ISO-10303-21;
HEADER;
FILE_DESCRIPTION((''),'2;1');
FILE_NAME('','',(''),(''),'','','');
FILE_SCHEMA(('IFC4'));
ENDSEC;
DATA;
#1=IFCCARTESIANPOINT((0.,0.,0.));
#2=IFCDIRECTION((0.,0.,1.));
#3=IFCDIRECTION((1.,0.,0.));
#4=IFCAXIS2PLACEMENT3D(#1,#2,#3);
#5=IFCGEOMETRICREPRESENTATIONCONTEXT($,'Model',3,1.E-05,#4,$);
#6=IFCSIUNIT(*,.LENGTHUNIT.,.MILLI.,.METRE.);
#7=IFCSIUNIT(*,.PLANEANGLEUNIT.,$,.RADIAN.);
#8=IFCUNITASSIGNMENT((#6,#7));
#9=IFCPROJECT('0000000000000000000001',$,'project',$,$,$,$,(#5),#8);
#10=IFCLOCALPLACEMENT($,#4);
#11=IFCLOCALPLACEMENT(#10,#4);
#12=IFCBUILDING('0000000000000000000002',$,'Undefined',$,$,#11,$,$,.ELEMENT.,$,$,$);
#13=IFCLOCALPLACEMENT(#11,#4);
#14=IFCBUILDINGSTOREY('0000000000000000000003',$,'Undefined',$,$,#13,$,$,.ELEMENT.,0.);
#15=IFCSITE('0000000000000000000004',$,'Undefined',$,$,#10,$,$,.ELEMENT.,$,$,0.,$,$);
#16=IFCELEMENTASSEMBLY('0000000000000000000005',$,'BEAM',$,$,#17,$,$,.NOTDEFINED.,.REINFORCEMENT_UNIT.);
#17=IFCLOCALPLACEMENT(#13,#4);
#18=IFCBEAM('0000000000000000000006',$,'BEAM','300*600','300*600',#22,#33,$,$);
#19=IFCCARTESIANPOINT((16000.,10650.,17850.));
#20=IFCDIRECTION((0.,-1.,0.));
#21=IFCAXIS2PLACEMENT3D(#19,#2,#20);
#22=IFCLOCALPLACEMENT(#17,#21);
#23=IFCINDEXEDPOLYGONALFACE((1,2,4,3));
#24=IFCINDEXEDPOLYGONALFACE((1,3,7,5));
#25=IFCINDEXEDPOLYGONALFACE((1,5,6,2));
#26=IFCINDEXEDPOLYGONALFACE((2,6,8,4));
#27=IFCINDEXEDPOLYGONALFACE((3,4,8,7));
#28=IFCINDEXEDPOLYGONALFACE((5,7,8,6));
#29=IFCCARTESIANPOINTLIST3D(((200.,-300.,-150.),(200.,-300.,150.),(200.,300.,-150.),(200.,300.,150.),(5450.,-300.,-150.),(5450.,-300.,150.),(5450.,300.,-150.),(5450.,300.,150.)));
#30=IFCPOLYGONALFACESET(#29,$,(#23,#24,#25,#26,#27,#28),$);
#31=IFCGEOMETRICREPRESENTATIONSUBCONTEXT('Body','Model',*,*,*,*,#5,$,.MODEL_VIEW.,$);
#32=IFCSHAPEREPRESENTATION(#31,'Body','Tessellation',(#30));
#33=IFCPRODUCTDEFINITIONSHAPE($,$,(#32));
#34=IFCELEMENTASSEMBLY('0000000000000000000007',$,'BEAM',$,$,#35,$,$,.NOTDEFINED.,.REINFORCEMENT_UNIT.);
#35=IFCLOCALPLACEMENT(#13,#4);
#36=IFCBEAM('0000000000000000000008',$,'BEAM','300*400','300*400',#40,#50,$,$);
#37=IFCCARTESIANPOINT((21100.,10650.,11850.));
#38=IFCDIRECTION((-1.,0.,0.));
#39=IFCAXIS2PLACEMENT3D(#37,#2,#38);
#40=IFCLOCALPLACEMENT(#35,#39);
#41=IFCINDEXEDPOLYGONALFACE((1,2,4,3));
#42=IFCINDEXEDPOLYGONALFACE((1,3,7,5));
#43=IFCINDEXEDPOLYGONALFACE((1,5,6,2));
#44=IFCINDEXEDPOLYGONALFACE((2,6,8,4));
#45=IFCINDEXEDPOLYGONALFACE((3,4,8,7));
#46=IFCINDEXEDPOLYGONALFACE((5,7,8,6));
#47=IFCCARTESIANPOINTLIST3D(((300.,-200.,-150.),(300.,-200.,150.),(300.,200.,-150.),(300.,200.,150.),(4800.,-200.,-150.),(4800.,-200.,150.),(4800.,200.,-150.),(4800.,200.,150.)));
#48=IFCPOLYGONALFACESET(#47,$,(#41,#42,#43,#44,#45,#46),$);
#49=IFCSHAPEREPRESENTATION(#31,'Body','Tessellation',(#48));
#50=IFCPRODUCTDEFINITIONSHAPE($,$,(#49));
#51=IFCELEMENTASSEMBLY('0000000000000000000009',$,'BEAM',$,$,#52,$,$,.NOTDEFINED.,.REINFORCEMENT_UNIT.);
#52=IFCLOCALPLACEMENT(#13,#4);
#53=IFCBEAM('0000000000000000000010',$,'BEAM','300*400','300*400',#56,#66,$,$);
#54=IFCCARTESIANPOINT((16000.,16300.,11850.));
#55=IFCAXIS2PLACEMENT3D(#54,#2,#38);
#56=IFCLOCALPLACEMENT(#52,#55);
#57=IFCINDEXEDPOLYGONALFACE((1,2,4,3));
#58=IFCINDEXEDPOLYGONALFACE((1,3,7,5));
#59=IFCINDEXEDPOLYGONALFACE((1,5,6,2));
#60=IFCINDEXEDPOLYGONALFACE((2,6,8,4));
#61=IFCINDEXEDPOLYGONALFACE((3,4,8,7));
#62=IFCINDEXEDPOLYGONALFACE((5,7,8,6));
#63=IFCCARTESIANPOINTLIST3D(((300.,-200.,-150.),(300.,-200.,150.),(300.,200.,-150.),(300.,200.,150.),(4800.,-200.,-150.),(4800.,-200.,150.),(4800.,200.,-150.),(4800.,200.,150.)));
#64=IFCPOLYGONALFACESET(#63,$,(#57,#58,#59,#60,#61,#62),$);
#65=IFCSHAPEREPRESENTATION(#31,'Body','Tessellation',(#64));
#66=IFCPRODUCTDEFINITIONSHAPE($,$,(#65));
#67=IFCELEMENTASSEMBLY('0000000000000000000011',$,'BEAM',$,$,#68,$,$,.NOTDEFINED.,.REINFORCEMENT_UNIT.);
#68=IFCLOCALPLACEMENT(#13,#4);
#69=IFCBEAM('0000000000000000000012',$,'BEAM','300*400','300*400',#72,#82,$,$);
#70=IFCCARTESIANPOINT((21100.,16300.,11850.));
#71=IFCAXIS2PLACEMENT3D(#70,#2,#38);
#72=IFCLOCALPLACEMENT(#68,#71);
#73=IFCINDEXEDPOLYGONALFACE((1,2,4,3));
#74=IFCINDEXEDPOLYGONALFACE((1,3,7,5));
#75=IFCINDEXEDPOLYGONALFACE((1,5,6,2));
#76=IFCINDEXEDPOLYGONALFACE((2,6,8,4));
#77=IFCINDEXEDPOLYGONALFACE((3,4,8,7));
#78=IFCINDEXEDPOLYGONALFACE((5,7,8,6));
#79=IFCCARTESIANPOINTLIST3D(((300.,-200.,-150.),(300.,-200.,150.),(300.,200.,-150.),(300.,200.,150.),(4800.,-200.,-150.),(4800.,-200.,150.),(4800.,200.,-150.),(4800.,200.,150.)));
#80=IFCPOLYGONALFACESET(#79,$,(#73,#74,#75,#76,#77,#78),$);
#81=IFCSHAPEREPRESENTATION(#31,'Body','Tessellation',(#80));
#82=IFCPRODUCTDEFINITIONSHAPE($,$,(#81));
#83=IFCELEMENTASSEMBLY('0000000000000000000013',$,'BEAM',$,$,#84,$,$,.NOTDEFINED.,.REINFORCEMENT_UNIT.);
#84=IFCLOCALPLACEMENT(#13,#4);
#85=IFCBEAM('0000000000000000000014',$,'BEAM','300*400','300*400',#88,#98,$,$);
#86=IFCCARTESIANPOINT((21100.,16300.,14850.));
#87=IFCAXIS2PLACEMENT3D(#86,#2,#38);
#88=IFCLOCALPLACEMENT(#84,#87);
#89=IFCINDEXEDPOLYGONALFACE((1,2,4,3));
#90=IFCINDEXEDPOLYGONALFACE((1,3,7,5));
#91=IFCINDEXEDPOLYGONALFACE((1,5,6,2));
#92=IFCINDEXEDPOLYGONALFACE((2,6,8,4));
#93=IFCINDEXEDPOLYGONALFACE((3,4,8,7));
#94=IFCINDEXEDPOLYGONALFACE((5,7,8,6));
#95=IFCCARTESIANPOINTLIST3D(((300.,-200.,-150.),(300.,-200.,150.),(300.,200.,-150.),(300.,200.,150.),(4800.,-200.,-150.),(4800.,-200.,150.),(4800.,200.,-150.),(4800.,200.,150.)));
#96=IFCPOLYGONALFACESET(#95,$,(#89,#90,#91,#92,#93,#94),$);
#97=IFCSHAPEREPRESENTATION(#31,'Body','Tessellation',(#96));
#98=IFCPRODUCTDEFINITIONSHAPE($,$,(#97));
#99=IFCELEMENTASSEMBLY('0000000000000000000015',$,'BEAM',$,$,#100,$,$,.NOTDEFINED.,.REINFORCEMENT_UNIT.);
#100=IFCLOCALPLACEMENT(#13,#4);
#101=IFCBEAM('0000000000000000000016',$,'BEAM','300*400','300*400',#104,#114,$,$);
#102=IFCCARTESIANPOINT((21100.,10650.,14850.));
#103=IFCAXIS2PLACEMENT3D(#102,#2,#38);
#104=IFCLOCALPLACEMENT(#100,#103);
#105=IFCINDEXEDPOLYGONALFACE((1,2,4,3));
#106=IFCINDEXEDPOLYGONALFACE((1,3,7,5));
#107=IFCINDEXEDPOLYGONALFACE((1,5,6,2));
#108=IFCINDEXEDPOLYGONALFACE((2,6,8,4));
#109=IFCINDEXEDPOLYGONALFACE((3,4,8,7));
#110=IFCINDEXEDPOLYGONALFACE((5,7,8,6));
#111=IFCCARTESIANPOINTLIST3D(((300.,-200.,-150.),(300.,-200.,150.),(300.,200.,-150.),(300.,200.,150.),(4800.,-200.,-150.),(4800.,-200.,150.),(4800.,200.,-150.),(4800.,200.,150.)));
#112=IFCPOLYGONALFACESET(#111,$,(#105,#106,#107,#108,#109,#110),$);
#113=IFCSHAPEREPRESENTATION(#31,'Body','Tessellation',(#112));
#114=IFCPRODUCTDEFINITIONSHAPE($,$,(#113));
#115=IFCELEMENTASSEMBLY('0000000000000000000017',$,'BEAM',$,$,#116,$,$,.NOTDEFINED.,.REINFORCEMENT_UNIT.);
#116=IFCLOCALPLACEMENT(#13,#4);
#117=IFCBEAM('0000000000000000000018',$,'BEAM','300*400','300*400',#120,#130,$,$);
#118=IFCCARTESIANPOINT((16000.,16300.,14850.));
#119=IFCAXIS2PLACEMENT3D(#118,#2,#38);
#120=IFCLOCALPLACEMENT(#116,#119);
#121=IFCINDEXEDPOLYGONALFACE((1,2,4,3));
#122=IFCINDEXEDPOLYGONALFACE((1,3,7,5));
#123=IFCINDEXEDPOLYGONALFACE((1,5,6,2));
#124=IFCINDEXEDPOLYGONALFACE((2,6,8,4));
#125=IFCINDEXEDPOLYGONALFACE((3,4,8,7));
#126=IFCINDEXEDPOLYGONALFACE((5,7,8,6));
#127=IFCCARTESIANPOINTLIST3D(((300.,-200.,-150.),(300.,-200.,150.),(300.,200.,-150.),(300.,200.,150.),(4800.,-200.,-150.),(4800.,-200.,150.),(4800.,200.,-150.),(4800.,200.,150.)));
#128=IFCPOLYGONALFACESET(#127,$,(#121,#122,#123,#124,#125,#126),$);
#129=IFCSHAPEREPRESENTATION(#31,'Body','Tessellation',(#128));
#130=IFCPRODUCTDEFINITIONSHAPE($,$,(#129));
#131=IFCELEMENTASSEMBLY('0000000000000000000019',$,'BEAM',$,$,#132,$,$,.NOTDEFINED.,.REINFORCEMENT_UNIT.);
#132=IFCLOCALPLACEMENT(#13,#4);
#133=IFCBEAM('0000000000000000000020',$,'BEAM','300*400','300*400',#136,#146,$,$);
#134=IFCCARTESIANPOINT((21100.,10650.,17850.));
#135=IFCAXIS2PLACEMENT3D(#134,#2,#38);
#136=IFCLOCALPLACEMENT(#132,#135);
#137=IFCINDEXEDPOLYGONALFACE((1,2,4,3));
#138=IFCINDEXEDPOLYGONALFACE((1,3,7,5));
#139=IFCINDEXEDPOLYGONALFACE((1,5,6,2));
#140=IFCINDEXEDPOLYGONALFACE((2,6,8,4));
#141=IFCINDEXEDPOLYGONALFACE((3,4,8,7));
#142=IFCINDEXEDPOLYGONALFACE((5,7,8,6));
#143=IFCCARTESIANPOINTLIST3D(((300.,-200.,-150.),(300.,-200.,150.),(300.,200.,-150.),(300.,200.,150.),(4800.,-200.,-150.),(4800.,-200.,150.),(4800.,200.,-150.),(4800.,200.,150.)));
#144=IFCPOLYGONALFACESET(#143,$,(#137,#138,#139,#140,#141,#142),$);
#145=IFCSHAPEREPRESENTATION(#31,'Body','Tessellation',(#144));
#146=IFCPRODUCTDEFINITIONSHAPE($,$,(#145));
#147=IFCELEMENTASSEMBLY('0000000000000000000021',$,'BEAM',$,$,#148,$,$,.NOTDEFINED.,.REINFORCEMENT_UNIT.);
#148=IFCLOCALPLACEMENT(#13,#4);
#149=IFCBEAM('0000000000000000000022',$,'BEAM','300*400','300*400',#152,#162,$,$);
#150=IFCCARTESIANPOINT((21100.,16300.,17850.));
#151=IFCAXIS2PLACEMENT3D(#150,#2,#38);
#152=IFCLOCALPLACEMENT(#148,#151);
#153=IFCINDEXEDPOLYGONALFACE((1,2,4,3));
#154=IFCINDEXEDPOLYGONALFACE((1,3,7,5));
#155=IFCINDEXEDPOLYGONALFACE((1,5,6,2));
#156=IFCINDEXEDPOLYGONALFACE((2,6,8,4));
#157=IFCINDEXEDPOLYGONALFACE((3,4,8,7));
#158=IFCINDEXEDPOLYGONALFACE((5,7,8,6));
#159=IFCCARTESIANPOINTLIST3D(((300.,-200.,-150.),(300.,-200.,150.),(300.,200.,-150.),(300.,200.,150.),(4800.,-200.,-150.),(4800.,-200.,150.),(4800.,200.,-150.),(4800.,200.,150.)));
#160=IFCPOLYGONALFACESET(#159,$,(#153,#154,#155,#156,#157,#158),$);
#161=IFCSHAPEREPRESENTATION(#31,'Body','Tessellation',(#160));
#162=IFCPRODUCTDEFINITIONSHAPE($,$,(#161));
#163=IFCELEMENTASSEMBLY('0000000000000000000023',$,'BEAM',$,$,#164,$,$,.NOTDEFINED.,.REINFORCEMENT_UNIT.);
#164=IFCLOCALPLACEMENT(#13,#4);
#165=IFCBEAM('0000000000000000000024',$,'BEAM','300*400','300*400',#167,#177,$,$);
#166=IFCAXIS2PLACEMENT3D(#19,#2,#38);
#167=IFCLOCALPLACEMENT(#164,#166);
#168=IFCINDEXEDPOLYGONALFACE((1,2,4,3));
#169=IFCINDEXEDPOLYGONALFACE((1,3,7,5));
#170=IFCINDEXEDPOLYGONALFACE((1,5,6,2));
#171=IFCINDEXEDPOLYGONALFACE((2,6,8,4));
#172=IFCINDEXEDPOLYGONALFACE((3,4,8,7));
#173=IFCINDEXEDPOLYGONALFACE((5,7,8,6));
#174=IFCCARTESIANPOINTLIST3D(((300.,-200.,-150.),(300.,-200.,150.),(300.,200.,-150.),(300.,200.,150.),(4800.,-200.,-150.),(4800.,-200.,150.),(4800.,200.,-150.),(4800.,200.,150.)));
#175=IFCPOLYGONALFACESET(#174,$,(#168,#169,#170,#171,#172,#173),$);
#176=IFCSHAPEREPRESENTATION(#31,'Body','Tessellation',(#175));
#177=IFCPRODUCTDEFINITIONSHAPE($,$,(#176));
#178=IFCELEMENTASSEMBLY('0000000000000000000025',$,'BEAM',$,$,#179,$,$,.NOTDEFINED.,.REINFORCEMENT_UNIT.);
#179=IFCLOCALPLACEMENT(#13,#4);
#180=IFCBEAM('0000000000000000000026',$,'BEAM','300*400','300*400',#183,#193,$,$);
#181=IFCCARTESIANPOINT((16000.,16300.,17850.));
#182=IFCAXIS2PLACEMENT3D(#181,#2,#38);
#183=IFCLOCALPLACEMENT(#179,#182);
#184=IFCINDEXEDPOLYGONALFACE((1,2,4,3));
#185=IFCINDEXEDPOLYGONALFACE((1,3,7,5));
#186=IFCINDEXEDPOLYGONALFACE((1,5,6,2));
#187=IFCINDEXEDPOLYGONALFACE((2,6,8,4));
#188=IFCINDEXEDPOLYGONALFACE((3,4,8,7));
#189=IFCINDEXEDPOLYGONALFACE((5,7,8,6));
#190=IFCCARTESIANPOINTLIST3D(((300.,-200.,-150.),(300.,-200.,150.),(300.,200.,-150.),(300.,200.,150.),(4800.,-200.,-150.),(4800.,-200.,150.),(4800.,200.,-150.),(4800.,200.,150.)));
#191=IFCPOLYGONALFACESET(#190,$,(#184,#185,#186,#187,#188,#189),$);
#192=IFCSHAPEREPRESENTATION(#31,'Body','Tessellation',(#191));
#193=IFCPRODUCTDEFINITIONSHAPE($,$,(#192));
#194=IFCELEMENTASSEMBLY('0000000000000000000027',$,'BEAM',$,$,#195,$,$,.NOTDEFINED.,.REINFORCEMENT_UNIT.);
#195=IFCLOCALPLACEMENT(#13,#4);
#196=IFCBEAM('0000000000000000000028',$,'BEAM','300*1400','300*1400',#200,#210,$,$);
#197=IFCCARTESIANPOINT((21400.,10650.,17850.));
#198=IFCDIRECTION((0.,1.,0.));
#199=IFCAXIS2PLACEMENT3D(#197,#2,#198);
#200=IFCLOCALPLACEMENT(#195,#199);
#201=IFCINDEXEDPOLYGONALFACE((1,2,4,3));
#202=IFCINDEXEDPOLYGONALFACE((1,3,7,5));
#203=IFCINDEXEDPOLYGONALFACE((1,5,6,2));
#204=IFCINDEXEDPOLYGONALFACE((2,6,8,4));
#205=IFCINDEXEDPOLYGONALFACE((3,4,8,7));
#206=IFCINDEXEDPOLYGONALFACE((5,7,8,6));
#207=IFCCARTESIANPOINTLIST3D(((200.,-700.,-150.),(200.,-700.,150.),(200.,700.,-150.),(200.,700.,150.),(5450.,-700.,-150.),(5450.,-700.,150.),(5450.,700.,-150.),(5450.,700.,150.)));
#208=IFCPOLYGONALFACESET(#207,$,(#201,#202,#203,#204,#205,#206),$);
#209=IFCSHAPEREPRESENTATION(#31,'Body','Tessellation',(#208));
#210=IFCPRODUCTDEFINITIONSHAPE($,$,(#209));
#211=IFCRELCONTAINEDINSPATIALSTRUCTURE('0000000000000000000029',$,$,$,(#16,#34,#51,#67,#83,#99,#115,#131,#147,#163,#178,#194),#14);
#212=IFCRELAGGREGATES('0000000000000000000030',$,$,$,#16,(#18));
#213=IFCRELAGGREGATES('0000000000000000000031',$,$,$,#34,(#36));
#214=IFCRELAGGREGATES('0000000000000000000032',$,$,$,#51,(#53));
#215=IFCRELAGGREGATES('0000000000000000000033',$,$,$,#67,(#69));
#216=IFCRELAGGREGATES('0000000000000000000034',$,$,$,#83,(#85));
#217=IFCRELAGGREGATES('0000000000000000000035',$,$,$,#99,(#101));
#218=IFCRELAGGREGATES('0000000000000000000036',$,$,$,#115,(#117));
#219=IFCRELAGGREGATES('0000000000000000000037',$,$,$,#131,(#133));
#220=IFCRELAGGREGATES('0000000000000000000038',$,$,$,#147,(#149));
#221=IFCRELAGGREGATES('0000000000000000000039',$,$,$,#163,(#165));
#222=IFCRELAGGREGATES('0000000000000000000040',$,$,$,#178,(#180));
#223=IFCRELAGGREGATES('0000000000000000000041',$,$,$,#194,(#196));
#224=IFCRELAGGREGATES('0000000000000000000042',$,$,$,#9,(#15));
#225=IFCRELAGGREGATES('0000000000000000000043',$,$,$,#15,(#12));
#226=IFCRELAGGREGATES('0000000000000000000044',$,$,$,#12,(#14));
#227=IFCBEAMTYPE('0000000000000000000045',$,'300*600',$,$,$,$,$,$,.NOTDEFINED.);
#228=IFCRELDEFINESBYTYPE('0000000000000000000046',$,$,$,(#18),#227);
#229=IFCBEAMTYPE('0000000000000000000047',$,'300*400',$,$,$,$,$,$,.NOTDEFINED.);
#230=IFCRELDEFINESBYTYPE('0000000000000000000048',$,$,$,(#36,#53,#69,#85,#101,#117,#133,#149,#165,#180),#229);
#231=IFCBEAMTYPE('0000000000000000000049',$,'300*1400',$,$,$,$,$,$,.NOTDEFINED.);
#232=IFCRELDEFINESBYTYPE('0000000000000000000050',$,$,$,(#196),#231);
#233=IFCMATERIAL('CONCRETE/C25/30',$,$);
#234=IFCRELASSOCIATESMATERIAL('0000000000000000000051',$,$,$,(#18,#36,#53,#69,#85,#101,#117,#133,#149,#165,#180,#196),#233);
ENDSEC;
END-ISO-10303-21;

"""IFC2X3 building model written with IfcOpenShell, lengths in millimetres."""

from ifc_helpers import new_model, si_unit, frame, origin_with_axes, origin_2d_with_axis, place, context, subcontext, project, spatial, rectangle, extrude, material, type_object, element, aggregate, save


model = new_model("IFC2X3")

# Units and contexts
model_context = context("Model", 3, precision=1e-05, world=origin_with_axes())
body_context = subcontext(model_context, "Body", "Model", "MODEL_VIEW")
ifc_project = project(units=[si_unit("LENGTHUNIT", "METRE", prefix="MILLI"), si_unit("PLANEANGLEUNIT", "RADIAN")], contexts=[model_context])

# Site, building, storey
site_placement = place(None, origin_with_axes())
site = spatial("IfcSite", under=ifc_project, at=site_placement, Name="Undefined", CompositionType="ELEMENT", RefElevation=0.0)
building_placement = place(site_placement, origin_with_axes())
building = spatial("IfcBuilding", under=site, at=building_placement, Name="Undefined", CompositionType="ELEMENT")
storey_placement = place(building_placement, origin_with_axes())
storey = spatial("IfcBuildingStorey", under=building, at=storey_placement, Name="Undefined", CompositionType="ELEMENT", Elevation=0.0)

# Shared definitions
ifc_material = material(Name="CONCRETE/C25/30")

# Element assemblies, beams
beam_type_1 = type_object("IfcBeamType", Name="300*600", PredefinedType="NOTDEFINED")
assembly_1_placement = place(storey_placement, origin_with_axes())
assembly_1 = element("IfcElementAssembly", 1, at=assembly_1_placement, inside=storey, Name="BEAM", AssemblyPlace="NOTDEFINED", PredefinedType="REINFORCEMENT_UNIT")
beam_1_placement = place(assembly_1_placement, frame((16000.0, 10650.0, 17850.0), z_axis=(0.0, 0.0, 1.0), x_axis=(0.0, -1.0, 0.0)))
beam_1 = element("IfcBeam", 2, at=beam_1_placement, type_object=beam_type_1, material=ifc_material, Name="BEAM", Description="300*600", ObjectType="300*600", context=body_context, shape_type="SweptSolid", body=[
    extrude(rectangle(XDim=600.0, YDim=300.0, at=origin_2d_with_axis()), frame((5450.0, 0.0, 0.0), z_axis=(-1.0, 0.0, 0.0), x_axis=(0.0, -1.0, 0.0)), (0.0, 0.0, 1.0), 5250.0),
])
aggregate(assembly_1, [beam_1])
assembly_2_placement = place(storey_placement, origin_with_axes())
assembly_2 = element("IfcElementAssembly", 3, at=assembly_2_placement, inside=storey, Name="BEAM", AssemblyPlace="NOTDEFINED", PredefinedType="REINFORCEMENT_UNIT")
beam_type_2 = type_object("IfcBeamType", Name="300*400", PredefinedType="NOTDEFINED")
beam_2_placement = place(assembly_2_placement, frame((21100.0, 10650.0, 11850.0), z_axis=(0.0, 0.0, 1.0), x_axis=(-1.0, 0.0, 0.0)))
beam_2 = element("IfcBeam", 4, at=beam_2_placement, type_object=beam_type_2, material=ifc_material, Name="BEAM", Description="300*400", ObjectType="300*400", context=body_context, shape_type="SweptSolid", body=[
    extrude(rectangle(XDim=400.0, YDim=300.0, at=origin_2d_with_axis()), frame((4800.0, 0.0, 0.0), z_axis=(-1.0, 0.0, 0.0), x_axis=(0.0, -1.0, 0.0)), (0.0, 0.0, 1.0), 4500.0),
])
aggregate(assembly_2, [beam_2])
assembly_3_placement = place(storey_placement, origin_with_axes())
assembly_3 = element("IfcElementAssembly", 5, at=assembly_3_placement, inside=storey, Name="BEAM", AssemblyPlace="NOTDEFINED", PredefinedType="REINFORCEMENT_UNIT")
beam_3_placement = place(assembly_3_placement, frame((16000.0, 16300.0, 11850.0), z_axis=(0.0, 0.0, 1.0), x_axis=(-1.0, 0.0, 0.0)))
beam_3 = element("IfcBeam", 6, at=beam_3_placement, type_object=beam_type_2, material=ifc_material, Name="BEAM", Description="300*400", ObjectType="300*400", context=body_context, shape_type="SweptSolid", body=[
    extrude(rectangle(XDim=400.0, YDim=300.0, at=origin_2d_with_axis()), frame((4800.0, 0.0, 0.0), z_axis=(-1.0, 0.0, 0.0), x_axis=(0.0, -1.0, 0.0)), (0.0, 0.0, 1.0), 4500.0),
])
aggregate(assembly_3, [beam_3])
assembly_4_placement = place(storey_placement, origin_with_axes())
assembly_4 = element("IfcElementAssembly", 7, at=assembly_4_placement, inside=storey, Name="BEAM", AssemblyPlace="NOTDEFINED", PredefinedType="REINFORCEMENT_UNIT")
beam_4_placement = place(assembly_4_placement, frame((21100.0, 16300.0, 11850.0), z_axis=(0.0, 0.0, 1.0), x_axis=(-1.0, 0.0, 0.0)))
beam_4 = element("IfcBeam", 8, at=beam_4_placement, type_object=beam_type_2, material=ifc_material, Name="BEAM", Description="300*400", ObjectType="300*400", context=body_context, shape_type="SweptSolid", body=[
    extrude(rectangle(XDim=400.0, YDim=300.0, at=origin_2d_with_axis()), frame((4800.0, 0.0, 0.0), z_axis=(-1.0, 0.0, 0.0), x_axis=(0.0, -1.0, 0.0)), (0.0, 0.0, 1.0), 4500.0),
])
aggregate(assembly_4, [beam_4])
assembly_5_placement = place(storey_placement, origin_with_axes())
assembly_5 = element("IfcElementAssembly", 9, at=assembly_5_placement, inside=storey, Name="BEAM", AssemblyPlace="NOTDEFINED", PredefinedType="REINFORCEMENT_UNIT")
beam_5_placement = place(assembly_5_placement, frame((21100.0, 16300.0, 14850.0), z_axis=(0.0, 0.0, 1.0), x_axis=(-1.0, 0.0, 0.0)))
beam_5 = element("IfcBeam", 10, at=beam_5_placement, type_object=beam_type_2, material=ifc_material, Name="BEAM", Description="300*400", ObjectType="300*400", context=body_context, shape_type="SweptSolid", body=[
    extrude(rectangle(XDim=400.0, YDim=300.0, at=origin_2d_with_axis()), frame((4800.0, 0.0, 0.0), z_axis=(-1.0, 0.0, 0.0), x_axis=(0.0, -1.0, 0.0)), (0.0, 0.0, 1.0), 4500.0),
])
aggregate(assembly_5, [beam_5])
assembly_6_placement = place(storey_placement, origin_with_axes())
assembly_6 = element("IfcElementAssembly", 11, at=assembly_6_placement, inside=storey, Name="BEAM", AssemblyPlace="NOTDEFINED", PredefinedType="REINFORCEMENT_UNIT")
beam_6_placement = place(assembly_6_placement, frame((21100.0, 10650.0, 14850.0), z_axis=(0.0, 0.0, 1.0), x_axis=(-1.0, 0.0, 0.0)))
beam_6 = element("IfcBeam", 12, at=beam_6_placement, type_object=beam_type_2, material=ifc_material, Name="BEAM", Description="300*400", ObjectType="300*400", context=body_context, shape_type="SweptSolid", body=[
    extrude(rectangle(XDim=400.0, YDim=300.0, at=origin_2d_with_axis()), frame((4800.0, 0.0, 0.0), z_axis=(-1.0, 0.0, 0.0), x_axis=(0.0, -1.0, 0.0)), (0.0, 0.0, 1.0), 4500.0),
])
aggregate(assembly_6, [beam_6])
assembly_7_placement = place(storey_placement, origin_with_axes())
assembly_7 = element("IfcElementAssembly", 13, at=assembly_7_placement, inside=storey, Name="BEAM", AssemblyPlace="NOTDEFINED", PredefinedType="REINFORCEMENT_UNIT")
beam_7_placement = place(assembly_7_placement, frame((16000.0, 16300.0, 14850.0), z_axis=(0.0, 0.0, 1.0), x_axis=(-1.0, 0.0, 0.0)))
beam_7 = element("IfcBeam", 14, at=beam_7_placement, type_object=beam_type_2, material=ifc_material, Name="BEAM", Description="300*400", ObjectType="300*400", context=body_context, shape_type="SweptSolid", body=[
    extrude(rectangle(XDim=400.0, YDim=300.0, at=origin_2d_with_axis()), frame((4800.0, 0.0, 0.0), z_axis=(-1.0, 0.0, 0.0), x_axis=(0.0, -1.0, 0.0)), (0.0, 0.0, 1.0), 4500.0),
])
aggregate(assembly_7, [beam_7])
assembly_8_placement = place(storey_placement, origin_with_axes())
assembly_8 = element("IfcElementAssembly", 15, at=assembly_8_placement, inside=storey, Name="BEAM", AssemblyPlace="NOTDEFINED", PredefinedType="REINFORCEMENT_UNIT")
beam_8_placement = place(assembly_8_placement, frame((21100.0, 10650.0, 17850.0), z_axis=(0.0, 0.0, 1.0), x_axis=(-1.0, 0.0, 0.0)))
beam_8 = element("IfcBeam", 16, at=beam_8_placement, type_object=beam_type_2, material=ifc_material, Name="BEAM", Description="300*400", ObjectType="300*400", context=body_context, shape_type="SweptSolid", body=[
    extrude(rectangle(XDim=400.0, YDim=300.0, at=origin_2d_with_axis()), frame((4800.0, 0.0, 0.0), z_axis=(-1.0, 0.0, 0.0), x_axis=(0.0, -1.0, 0.0)), (0.0, 0.0, 1.0), 4500.0),
])
aggregate(assembly_8, [beam_8])
assembly_9_placement = place(storey_placement, origin_with_axes())
assembly_9 = element("IfcElementAssembly", 17, at=assembly_9_placement, inside=storey, Name="BEAM", AssemblyPlace="NOTDEFINED", PredefinedType="REINFORCEMENT_UNIT")
beam_9_placement = place(assembly_9_placement, frame((21100.0, 16300.0, 17850.0), z_axis=(0.0, 0.0, 1.0), x_axis=(-1.0, 0.0, 0.0)))
beam_9 = element("IfcBeam", 18, at=beam_9_placement, type_object=beam_type_2, material=ifc_material, Name="BEAM", Description="300*400", ObjectType="300*400", context=body_context, shape_type="SweptSolid", body=[
    extrude(rectangle(XDim=400.0, YDim=300.0, at=origin_2d_with_axis()), frame((4800.0, 0.0, 0.0), z_axis=(-1.0, 0.0, 0.0), x_axis=(0.0, -1.0, 0.0)), (0.0, 0.0, 1.0), 4500.0),
])
aggregate(assembly_9, [beam_9])
assembly_10_placement = place(storey_placement, origin_with_axes())
assembly_10 = element("IfcElementAssembly", 19, at=assembly_10_placement, inside=storey, Name="BEAM", AssemblyPlace="NOTDEFINED", PredefinedType="REINFORCEMENT_UNIT")
beam_10_placement = place(assembly_10_placement, frame((16000.0, 10650.0, 17850.0), z_axis=(0.0, 0.0, 1.0), x_axis=(-1.0, 0.0, 0.0)))
beam_10 = element("IfcBeam", 20, at=beam_10_placement, type_object=beam_type_2, material=ifc_material, Name="BEAM", Description="300*400", ObjectType="300*400", context=body_context, shape_type="SweptSolid", body=[
    extrude(rectangle(XDim=400.0, YDim=300.0, at=origin_2d_with_axis()), frame((4800.0, 0.0, 0.0), z_axis=(-1.0, 0.0, 0.0), x_axis=(0.0, -1.0, 0.0)), (0.0, 0.0, 1.0), 4500.0),
])
aggregate(assembly_10, [beam_10])
assembly_11_placement = place(storey_placement, origin_with_axes())
assembly_11 = element("IfcElementAssembly", 21, at=assembly_11_placement, inside=storey, Name="BEAM", AssemblyPlace="NOTDEFINED", PredefinedType="REINFORCEMENT_UNIT")
beam_11_placement = place(assembly_11_placement, frame((16000.0, 16300.0, 17850.0), z_axis=(0.0, 0.0, 1.0), x_axis=(-1.0, 0.0, 0.0)))
beam_11 = element("IfcBeam", 22, at=beam_11_placement, type_object=beam_type_2, material=ifc_material, Name="BEAM", Description="300*400", ObjectType="300*400", context=body_context, shape_type="SweptSolid", body=[
    extrude(rectangle(XDim=400.0, YDim=300.0, at=origin_2d_with_axis()), frame((4800.0, 0.0, 0.0), z_axis=(-1.0, 0.0, 0.0), x_axis=(0.0, -1.0, 0.0)), (0.0, 0.0, 1.0), 4500.0),
])
aggregate(assembly_11, [beam_11])
assembly_12_placement = place(storey_placement, origin_with_axes())
assembly_12 = element("IfcElementAssembly", 23, at=assembly_12_placement, inside=storey, Name="BEAM", AssemblyPlace="NOTDEFINED", PredefinedType="REINFORCEMENT_UNIT")
beam_type_3 = type_object("IfcBeamType", Name="300*1400", PredefinedType="NOTDEFINED")
beam_12_placement = place(assembly_12_placement, frame((21400.0, 10650.0, 17850.0), z_axis=(0.0, 0.0, 1.0), x_axis=(0.0, 1.0, 0.0)))
beam_12 = element("IfcBeam", 24, at=beam_12_placement, type_object=beam_type_3, material=ifc_material, Name="BEAM", Description="300*1400", ObjectType="300*1400", context=body_context, shape_type="SweptSolid", body=[
    extrude(rectangle(XDim=1400.0, YDim=300.0, at=origin_2d_with_axis()), frame((5450.0, 0.0, 0.0), z_axis=(-1.0, 0.0, 0.0), x_axis=(0.0, -1.0, 0.0)), (0.0, 0.0, 1.0), 5250.0),
])
aggregate(assembly_12, [beam_12])

save(model, "model.ifc")
